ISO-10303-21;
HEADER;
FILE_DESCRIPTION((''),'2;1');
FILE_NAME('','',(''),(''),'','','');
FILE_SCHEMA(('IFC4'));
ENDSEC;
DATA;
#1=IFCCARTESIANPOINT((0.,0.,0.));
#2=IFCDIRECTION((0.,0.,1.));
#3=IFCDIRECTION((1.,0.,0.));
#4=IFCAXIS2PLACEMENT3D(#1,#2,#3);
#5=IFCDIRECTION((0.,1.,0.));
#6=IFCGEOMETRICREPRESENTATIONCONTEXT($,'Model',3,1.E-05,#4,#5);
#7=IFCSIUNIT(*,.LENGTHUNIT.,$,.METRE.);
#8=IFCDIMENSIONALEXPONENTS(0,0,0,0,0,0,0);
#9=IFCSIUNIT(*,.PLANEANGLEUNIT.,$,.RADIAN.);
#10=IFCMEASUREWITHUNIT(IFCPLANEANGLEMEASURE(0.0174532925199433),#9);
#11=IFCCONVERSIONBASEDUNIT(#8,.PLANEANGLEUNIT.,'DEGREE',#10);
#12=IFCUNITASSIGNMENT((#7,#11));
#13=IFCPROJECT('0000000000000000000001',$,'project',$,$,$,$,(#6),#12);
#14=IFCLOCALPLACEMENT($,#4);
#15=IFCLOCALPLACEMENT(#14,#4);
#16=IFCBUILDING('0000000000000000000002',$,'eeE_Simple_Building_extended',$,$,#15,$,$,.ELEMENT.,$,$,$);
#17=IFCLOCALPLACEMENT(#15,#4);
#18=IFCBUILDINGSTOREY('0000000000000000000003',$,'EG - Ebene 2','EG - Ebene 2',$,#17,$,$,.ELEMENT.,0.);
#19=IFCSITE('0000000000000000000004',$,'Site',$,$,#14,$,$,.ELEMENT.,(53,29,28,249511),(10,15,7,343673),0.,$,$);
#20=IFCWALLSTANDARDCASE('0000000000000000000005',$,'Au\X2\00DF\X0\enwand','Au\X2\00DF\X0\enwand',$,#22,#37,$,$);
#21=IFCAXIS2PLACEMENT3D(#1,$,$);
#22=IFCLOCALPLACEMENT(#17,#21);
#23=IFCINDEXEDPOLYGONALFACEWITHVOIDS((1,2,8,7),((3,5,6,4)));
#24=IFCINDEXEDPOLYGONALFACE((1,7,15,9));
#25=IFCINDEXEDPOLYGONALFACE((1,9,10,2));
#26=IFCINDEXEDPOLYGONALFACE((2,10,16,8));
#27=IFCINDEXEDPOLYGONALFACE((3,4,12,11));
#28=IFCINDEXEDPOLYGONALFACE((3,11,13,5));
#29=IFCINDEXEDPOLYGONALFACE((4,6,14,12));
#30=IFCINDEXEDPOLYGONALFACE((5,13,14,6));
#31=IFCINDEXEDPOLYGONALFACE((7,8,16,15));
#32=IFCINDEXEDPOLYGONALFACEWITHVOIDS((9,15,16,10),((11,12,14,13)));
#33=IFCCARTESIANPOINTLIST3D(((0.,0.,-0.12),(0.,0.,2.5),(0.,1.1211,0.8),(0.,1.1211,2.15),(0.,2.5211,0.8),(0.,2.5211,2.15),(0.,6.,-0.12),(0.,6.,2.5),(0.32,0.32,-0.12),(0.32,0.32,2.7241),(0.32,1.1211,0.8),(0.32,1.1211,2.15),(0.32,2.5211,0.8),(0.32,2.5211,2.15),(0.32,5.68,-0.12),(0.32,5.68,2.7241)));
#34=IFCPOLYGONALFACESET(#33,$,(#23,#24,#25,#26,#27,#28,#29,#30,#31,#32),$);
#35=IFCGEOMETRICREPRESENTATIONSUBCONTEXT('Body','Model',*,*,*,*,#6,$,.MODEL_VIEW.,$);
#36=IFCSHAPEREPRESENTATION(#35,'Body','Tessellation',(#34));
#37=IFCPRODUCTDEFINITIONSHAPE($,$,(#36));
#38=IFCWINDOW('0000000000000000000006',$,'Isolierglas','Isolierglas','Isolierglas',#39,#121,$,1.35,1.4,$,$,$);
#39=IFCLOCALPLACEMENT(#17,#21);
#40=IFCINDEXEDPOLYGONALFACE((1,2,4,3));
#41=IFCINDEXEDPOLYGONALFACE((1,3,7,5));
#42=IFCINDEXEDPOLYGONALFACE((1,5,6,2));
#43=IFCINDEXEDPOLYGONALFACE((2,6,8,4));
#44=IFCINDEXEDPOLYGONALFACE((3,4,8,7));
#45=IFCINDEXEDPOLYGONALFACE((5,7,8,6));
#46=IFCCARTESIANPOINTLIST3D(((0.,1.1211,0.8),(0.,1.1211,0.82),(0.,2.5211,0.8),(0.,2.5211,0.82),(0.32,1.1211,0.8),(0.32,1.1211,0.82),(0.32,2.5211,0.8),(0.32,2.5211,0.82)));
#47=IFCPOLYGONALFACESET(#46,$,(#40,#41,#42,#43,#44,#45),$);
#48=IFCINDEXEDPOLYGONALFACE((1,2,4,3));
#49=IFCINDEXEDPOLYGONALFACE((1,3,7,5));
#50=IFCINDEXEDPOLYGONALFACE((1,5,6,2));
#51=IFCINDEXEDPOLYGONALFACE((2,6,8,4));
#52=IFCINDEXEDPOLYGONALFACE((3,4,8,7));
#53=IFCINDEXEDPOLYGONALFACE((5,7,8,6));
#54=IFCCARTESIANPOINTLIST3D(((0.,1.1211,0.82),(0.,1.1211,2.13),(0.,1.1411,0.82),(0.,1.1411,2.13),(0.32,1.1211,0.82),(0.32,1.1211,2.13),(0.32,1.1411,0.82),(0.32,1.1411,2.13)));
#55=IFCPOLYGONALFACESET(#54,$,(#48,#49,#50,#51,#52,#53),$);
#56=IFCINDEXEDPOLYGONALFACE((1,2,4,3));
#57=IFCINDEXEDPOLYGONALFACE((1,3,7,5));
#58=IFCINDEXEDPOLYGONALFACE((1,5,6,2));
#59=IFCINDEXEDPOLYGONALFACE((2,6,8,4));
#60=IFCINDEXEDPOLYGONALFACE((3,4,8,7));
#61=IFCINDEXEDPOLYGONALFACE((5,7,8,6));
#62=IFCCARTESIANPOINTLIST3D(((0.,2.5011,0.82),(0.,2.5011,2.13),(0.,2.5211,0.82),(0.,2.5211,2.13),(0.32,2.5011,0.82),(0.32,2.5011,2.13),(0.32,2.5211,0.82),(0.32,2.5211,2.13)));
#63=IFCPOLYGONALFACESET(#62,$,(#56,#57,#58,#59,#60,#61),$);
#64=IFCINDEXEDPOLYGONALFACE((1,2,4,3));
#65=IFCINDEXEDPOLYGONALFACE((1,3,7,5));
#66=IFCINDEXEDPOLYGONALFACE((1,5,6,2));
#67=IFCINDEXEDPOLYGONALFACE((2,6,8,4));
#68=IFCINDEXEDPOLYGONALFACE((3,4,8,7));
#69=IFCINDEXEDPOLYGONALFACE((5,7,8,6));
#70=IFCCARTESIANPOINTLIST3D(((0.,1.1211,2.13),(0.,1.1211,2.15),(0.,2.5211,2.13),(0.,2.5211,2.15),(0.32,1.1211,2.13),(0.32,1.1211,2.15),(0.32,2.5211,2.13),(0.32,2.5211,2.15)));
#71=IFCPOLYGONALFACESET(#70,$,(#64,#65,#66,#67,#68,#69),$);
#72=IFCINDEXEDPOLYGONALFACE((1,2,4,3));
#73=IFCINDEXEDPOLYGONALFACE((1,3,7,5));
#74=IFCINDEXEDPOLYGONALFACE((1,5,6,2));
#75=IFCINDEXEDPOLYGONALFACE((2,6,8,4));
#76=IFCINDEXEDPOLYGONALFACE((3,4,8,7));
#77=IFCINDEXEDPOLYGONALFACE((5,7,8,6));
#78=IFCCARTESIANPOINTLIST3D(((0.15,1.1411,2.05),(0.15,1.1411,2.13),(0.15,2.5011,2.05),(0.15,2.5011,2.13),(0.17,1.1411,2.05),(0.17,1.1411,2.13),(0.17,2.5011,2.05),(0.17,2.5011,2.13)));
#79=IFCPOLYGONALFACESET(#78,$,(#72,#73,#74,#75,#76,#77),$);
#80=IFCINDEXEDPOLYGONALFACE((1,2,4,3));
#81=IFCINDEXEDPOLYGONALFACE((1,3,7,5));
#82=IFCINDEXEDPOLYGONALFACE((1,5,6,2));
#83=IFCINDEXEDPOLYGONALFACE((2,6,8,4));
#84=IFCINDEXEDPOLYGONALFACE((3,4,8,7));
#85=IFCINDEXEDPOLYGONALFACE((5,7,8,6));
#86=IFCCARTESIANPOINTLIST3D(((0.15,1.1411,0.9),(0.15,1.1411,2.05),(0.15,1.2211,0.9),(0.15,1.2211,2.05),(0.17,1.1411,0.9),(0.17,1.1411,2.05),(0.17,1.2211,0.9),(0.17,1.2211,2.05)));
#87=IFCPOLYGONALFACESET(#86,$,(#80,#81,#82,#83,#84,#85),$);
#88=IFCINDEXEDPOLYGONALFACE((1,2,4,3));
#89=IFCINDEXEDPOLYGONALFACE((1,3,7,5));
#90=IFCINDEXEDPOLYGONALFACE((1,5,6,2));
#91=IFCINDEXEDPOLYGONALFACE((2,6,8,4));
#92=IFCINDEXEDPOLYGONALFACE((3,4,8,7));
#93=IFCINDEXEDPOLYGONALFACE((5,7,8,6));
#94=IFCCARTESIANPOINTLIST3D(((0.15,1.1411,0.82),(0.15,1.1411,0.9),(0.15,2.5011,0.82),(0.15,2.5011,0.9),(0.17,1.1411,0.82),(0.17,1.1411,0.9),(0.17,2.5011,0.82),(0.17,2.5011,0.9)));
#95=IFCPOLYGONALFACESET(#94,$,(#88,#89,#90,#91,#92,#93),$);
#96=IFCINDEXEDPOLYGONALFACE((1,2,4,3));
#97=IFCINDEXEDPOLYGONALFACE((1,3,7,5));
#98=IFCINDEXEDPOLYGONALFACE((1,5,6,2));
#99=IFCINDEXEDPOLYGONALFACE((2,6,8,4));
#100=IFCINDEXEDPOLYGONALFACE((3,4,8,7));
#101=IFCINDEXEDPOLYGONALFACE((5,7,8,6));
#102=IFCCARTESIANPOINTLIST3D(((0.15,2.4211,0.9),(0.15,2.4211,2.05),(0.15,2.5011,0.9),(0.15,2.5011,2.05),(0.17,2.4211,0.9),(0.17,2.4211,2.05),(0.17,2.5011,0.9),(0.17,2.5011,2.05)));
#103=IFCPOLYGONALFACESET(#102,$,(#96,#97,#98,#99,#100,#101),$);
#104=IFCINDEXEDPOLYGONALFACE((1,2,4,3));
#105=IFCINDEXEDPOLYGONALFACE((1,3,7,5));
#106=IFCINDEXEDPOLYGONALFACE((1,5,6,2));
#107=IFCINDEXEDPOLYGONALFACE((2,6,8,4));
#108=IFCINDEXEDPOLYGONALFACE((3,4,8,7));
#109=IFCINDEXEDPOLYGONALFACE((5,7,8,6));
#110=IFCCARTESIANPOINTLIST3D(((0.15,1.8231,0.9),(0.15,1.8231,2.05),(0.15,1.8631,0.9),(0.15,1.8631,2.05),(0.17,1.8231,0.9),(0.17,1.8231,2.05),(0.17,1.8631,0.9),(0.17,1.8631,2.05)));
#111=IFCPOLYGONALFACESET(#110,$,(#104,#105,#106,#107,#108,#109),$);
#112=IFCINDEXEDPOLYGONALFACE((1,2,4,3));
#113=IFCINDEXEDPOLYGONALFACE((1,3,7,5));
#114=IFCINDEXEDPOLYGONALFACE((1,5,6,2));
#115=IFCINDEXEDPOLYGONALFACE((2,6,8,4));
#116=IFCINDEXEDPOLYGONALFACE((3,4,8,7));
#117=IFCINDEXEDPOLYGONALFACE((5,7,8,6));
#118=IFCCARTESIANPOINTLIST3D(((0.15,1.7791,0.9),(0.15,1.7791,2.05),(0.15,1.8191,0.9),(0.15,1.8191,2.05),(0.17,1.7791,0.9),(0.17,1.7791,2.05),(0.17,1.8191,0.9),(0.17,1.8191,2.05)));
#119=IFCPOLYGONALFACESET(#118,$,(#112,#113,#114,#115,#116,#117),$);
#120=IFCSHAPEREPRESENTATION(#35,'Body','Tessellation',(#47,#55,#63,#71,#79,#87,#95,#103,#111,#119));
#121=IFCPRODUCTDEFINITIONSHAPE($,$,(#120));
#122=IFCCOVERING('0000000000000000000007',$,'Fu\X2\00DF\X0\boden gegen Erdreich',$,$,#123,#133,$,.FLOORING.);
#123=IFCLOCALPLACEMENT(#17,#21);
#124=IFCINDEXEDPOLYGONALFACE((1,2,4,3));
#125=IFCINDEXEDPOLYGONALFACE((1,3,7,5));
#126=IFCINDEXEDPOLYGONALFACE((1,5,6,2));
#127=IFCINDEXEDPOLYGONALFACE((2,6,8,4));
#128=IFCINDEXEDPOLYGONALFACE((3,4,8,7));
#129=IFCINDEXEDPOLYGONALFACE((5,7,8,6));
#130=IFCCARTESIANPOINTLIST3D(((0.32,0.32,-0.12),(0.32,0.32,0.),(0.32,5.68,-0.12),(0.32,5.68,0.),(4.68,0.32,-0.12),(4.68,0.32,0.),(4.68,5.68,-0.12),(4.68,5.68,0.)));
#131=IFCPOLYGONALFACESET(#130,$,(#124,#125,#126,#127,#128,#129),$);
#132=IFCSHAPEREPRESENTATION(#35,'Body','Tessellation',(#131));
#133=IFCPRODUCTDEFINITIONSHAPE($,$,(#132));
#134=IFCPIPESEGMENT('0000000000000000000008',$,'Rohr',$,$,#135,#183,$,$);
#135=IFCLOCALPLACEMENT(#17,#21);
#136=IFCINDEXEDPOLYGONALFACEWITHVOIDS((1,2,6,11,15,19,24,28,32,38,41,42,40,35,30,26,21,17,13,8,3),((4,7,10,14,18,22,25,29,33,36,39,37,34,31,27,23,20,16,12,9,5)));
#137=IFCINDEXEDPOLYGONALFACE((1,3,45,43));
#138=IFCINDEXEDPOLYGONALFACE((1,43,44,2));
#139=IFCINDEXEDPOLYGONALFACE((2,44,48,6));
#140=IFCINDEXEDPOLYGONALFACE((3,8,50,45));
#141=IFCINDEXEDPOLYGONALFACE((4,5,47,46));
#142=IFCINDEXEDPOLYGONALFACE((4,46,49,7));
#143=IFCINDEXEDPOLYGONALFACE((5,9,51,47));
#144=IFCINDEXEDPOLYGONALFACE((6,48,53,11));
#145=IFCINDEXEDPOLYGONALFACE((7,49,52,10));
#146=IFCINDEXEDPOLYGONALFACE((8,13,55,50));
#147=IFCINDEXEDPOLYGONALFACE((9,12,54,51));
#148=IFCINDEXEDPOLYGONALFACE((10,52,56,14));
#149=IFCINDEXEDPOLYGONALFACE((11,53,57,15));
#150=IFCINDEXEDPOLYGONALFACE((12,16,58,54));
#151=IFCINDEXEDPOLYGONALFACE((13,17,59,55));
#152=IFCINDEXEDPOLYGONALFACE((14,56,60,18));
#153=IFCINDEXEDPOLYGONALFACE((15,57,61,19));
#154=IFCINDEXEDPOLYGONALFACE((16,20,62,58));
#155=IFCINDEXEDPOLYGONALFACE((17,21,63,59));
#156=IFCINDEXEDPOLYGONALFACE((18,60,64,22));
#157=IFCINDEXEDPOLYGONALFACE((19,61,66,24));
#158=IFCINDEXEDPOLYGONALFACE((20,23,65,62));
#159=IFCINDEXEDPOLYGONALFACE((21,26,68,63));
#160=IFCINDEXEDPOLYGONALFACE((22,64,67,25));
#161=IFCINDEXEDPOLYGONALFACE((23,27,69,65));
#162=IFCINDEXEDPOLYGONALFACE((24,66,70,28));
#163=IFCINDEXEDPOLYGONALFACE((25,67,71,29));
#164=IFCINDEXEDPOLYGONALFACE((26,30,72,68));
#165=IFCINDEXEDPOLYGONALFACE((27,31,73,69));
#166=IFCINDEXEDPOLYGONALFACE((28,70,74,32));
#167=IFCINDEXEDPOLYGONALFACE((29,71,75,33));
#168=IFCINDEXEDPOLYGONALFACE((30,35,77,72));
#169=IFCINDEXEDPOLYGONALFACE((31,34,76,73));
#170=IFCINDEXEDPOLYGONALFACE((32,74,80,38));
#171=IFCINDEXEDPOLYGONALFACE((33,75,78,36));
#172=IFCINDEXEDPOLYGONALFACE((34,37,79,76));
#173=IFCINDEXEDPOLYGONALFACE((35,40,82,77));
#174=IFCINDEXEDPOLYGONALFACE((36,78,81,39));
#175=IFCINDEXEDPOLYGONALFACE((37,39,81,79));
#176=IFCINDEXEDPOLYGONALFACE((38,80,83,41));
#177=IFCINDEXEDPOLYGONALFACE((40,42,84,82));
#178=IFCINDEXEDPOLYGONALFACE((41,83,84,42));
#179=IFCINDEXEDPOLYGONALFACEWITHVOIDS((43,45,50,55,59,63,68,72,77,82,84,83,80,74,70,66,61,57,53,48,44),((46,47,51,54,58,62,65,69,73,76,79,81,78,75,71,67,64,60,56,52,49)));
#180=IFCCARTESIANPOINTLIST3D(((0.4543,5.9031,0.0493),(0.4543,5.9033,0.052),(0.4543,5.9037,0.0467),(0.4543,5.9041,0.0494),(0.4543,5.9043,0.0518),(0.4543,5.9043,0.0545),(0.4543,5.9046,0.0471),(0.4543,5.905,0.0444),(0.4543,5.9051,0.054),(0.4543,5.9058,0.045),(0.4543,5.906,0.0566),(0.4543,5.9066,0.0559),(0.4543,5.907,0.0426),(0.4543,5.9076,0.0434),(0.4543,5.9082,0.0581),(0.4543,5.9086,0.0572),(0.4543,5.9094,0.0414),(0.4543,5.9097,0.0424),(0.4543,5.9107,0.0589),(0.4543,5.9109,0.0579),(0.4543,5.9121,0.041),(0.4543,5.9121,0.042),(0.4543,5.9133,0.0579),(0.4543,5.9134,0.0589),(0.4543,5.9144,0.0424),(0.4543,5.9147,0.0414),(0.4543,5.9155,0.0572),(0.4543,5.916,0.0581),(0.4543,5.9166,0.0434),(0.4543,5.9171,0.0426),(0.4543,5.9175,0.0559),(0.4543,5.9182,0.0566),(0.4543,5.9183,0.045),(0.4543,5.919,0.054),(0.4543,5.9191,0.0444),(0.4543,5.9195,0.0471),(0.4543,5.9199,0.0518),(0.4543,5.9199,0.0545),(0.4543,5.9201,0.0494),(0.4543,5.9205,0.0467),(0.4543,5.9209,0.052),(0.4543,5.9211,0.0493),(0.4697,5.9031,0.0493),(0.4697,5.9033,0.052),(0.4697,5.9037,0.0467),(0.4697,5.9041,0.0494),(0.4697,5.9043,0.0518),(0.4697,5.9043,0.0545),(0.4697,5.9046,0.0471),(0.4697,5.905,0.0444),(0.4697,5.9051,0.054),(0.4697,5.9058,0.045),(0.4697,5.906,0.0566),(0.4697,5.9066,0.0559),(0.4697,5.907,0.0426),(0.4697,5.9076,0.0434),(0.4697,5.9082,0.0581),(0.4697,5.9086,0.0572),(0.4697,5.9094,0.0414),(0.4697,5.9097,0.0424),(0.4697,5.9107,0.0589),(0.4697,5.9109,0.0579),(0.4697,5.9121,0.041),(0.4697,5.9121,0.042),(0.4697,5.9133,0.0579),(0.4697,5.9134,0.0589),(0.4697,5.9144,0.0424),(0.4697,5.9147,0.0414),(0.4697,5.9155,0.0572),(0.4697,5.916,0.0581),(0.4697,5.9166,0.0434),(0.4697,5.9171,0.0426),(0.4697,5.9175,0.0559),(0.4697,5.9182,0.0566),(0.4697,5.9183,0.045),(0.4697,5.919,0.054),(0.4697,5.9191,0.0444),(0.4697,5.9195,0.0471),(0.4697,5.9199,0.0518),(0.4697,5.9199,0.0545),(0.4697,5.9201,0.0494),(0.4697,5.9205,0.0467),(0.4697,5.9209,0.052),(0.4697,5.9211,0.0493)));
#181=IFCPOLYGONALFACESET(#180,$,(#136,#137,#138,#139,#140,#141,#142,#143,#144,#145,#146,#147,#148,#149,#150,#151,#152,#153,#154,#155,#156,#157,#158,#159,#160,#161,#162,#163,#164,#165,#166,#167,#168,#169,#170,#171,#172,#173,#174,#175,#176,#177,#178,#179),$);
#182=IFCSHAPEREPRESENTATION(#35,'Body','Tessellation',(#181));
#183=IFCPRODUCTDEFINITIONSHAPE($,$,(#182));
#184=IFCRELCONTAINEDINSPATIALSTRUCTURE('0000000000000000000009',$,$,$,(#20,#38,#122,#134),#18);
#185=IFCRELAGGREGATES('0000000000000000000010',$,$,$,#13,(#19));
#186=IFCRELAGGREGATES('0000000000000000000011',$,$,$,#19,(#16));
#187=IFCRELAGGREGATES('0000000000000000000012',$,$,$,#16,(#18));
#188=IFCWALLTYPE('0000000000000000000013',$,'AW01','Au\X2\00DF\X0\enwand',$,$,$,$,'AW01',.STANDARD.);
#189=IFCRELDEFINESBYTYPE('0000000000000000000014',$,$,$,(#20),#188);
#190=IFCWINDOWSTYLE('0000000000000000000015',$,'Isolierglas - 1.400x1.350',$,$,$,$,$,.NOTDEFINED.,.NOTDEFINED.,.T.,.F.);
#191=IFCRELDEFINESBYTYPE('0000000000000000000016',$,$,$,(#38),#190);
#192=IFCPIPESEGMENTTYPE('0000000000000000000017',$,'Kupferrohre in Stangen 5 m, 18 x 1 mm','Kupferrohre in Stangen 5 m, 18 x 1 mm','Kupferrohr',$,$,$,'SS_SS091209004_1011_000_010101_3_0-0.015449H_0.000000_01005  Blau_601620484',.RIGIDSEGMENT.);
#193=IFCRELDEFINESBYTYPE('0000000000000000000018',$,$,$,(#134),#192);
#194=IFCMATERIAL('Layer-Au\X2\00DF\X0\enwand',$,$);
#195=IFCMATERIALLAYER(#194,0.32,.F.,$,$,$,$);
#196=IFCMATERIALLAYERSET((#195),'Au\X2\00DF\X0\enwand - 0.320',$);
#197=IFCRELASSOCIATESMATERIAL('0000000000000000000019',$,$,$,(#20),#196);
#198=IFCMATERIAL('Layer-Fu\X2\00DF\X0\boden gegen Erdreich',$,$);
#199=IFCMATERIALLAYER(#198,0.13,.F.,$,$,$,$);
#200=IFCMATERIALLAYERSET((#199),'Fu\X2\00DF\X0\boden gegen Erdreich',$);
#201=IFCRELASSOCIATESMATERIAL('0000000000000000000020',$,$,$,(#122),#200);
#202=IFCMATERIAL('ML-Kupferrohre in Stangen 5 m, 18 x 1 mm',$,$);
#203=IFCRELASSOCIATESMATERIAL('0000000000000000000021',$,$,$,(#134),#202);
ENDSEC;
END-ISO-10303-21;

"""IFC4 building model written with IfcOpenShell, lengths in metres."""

from ifc_helpers import new_model, entity, si_unit, converted_unit, direction, frame, origin_with_axes, origin_2d_with_axis, place, context, subcontext, project, spatial, polyline, rectangle, hollow_circle, outline, extrude, clip, bounded_halfspace, source, transform, mapped, material, layer, layer_set, layer_usage, type_object, element, fill, save


model = new_model("IFC4")

# Units and contexts
model_context = context("Model", 3, precision=1e-05, world=origin_with_axes(), true_north=direction((0.0, 1.0, 0.0)))
body_context = subcontext(model_context, "Body", "Model", "MODEL_VIEW")
ifc_project = project(units=[si_unit("LENGTHUNIT", "METRE"), converted_unit("PLANEANGLEUNIT", "DEGREE", entity("IfcPlaneAngleMeasure", 0.0174532925199433), si_unit("PLANEANGLEUNIT", "RADIAN"), dimensions=[0, 0, 0, 0, 0, 0, 0])], contexts=[model_context])

# Site, building, storey
site_placement = place(None, origin_with_axes())
site = spatial("IfcSite", under=ifc_project, at=site_placement, Name="Site", CompositionType="ELEMENT", RefLatitude=(53, 29, 28, 249511), RefLongitude=(10, 15, 7, 343673), RefElevation=0.0)
building_placement = place(site_placement, origin_with_axes())
building = spatial("IfcBuilding", under=site, at=building_placement, Name="eeE_Simple_Building_extended", CompositionType="ELEMENT")
storey_placement = place(building_placement, origin_with_axes())
storey = spatial("IfcBuildingStorey", under=building, at=storey_placement, Name="EG - Ebene 2", Description="EG - Ebene 2", CompositionType="ELEMENT", Elevation=0.0)

# Wall, opening, window
ifc_material_1 = material(Name="Layer-Außenwand")
ifc_layer_1 = layer(ifc_material_1, 0.32, ventilated=False)
ifc_layer_set_1 = layer_set([ifc_layer_1], Name="Außenwand - 0.320")
ifc_layer_usage_1 = layer_usage(ifc_layer_set_1, "AXIS2", "POSITIVE", 0.0)
wall_type = type_object("IfcWallType", Name="AW01", Description="Außenwand", ElementType="AW01", PredefinedType="STANDARD")
wall_placement = place(storey_placement, frame((0.32, 5.68, -0.12), z_axis=(0.0, 0.0, 1.0), x_axis=(0.0, -1.0, 0.0)))
wall = element("IfcWallStandardCase", 1, at=wall_placement, inside=storey, type_object=wall_type, material=ifc_layer_usage_1, Name="Außenwand", Description="Außenwand", context=body_context, shape_type="Clipping", body=[
    clip(extrude(outline(polyline([(0.0, 0.0), (5.36, 0.0), (5.68, 0.32), (-0.32, 0.32), (0.0, 0.0)])), frame((0.0, 0.0, 0.0), z_axis=(0.0, 0.0, -1.0), x_axis=(1.0, 0.0, 0.0)), (0.0, 0.0, -1.0), 4.3705), bounded_halfspace(frame((6.08, 2.18, 4.3705), z_axis=(0.0, 0.573576, -0.819152), x_axis=(1.0, 0.0, 0.0)), True, frame((6.08, 2.18, 0.12), z_axis=(0.0, 0.0, 1.0), x_axis=(-1.0, 0.0, 0.0)), polyline([(0.0, 0.0), (6.8, 0.0), (6.8, 2.9), (0.0, 2.9), (0.0, 0.0)]))),
])
opening_placement = place(wall_placement, frame((4.5589, -0.42, 0.92), z_axis=(0.0, 0.0, 1.0), x_axis=(1.0, 0.0, 0.0)))
opening = element("IfcOpeningElement", 2, at=opening_placement, cuts=wall, context=body_context, shape_type="SweptSolid", body=[
    extrude(outline(polyline([(0.0, 0.0), (1.4, 0.0), (1.4, 1.35), (0.0, 1.35), (0.0, 0.0), (0.0, 0.0)])), frame((0.0, 0.0, 0.0), z_axis=(0.0, 1.0, 0.0), x_axis=(-1.0, 0.0, 0.0)), (0.0, 0.0, 1.0), 0.52),
])
window_style = type_object("IfcWindowStyle", Name="Isolierglas - 1.400x1.350", ConstructionType="NOTDEFINED", OperationType="NOTDEFINED", ParameterTakesPrecedence=True, Sizeable=False)
shared_shape_1 = source(origin_with_axes(), body_context, "Body", "SweptSolid", [
    extrude(rectangle(XDim=1.4, YDim=0.32, at=origin_2d_with_axis()), frame((0.7, 0.16, 0.0), z_axis=(0.0, 0.0, 1.0), x_axis=(1.0, 0.0, 0.0)), (0.0, 0.0, 1.0), 0.02),
    extrude(rectangle(XDim=0.02, YDim=0.32, at=origin_2d_with_axis()), frame((0.01, 0.16, 0.02), z_axis=(0.0, 0.0, 1.0), x_axis=(1.0, 0.0, 0.0)), (0.0, 0.0, 1.0), 1.31),
    extrude(rectangle(XDim=0.02, YDim=0.32, at=origin_2d_with_axis()), frame((1.39, 0.16, 0.02), z_axis=(0.0, 0.0, 1.0), x_axis=(1.0, 0.0, 0.0)), (0.0, 0.0, 1.0), 1.31),
    extrude(rectangle(XDim=1.4, YDim=0.32, at=origin_2d_with_axis()), frame((0.7, 0.16, 1.33), z_axis=(0.0, 0.0, 1.0), x_axis=(1.0, 0.0, 0.0)), (0.0, 0.0, 1.0), 0.02),
    extrude(rectangle(XDim=1.36, YDim=0.02, at=origin_2d_with_axis()), frame((0.7, 0.16, 1.25), z_axis=(0.0, 0.0, 1.0), x_axis=(1.0, 0.0, 0.0)), (0.0, 0.0, 1.0), 0.08),
    extrude(rectangle(XDim=0.08, YDim=0.02, at=origin_2d_with_axis()), frame((0.06, 0.16, 0.1), z_axis=(0.0, 0.0, 1.0), x_axis=(1.0, 0.0, 0.0)), (0.0, 0.0, 1.0), 1.15),
    extrude(rectangle(XDim=1.36, YDim=0.02, at=origin_2d_with_axis()), frame((0.7, 0.16, 0.02), z_axis=(0.0, 0.0, 1.0), x_axis=(1.0, 0.0, 0.0)), (0.0, 0.0, 1.0), 0.08),
    extrude(rectangle(XDim=0.08, YDim=0.02, at=origin_2d_with_axis()), frame((1.34, 0.16, 0.1), z_axis=(0.0, 0.0, 1.0), x_axis=(1.0, 0.0, 0.0)), (0.0, 0.0, 1.0), 1.15),
    extrude(rectangle(XDim=0.04, YDim=0.02, at=origin_2d_with_axis()), frame((0.722, 0.16, 0.1), z_axis=(0.0, 0.0, 1.0), x_axis=(1.0, 0.0, 0.0)), (0.0, 0.0, 1.0), 1.15),
    extrude(rectangle(XDim=0.04, YDim=0.02, at=origin_2d_with_axis()), frame((0.678, 0.16, 0.1), z_axis=(0.0, 0.0, 1.0), x_axis=(1.0, 0.0, 0.0)), (0.0, 0.0, 1.0), 1.15),
])
window_placement = place(opening_placement, frame((0.0, 0.1, 0.0), z_axis=(0.0, 0.0, 1.0), x_axis=(-1.0, 0.0, 0.0)))
window = element("IfcWindow", 3, at=window_placement, inside=storey, type_object=window_style, Name="Isolierglas", Description="Isolierglas", ObjectType="Isolierglas", OverallHeight=1.35, OverallWidth=1.4, context=body_context, shape_type="MappedRepresentation", body=[
    mapped(shared_shape_1, transform((0.0, -0.32, 0.0), x_axis=(1.0, 0.0, 0.0), y_axis=(0.0, 1.0, 0.0), z_axis=(0.0, 0.0, 1.0), scale=1.0)),
])
fill(opening, window)

# Covering
ifc_material_2 = material(Name="Layer-Fußboden gegen Erdreich")
ifc_layer_2 = layer(ifc_material_2, 0.13, ventilated=False)
ifc_layer_set_2 = layer_set([ifc_layer_2], Name="Fußboden gegen Erdreich")
ifc_layer_usage_2 = layer_usage(ifc_layer_set_2, "AXIS2", "POSITIVE", 0.0)
covering_placement = place(storey_placement, frame((0.32, 5.68, -0.12), z_axis=(0.0, 0.0, 1.0), x_axis=(1.0, 0.0, 0.0)))
element("IfcCovering", 4, at=covering_placement, inside=storey, material=ifc_layer_usage_2, Name="Fußboden gegen Erdreich", PredefinedType="FLOORING", context=body_context, shape_type="SweptSolid", body=[
    extrude(outline(polyline([(0.0, 0.0), (5.36, 0.0), (5.36, 4.36), (0.0, 4.36), (0.0, 0.0)])), frame((0.0, 0.0, 0.0), z_axis=(0.0, 0.0, 1.0), x_axis=(0.0, -1.0, 0.0)), (0.0, 0.0, 1.0), 0.12),
])

# Pipe segment
ifc_material_3 = material(Name="ML-Kupferrohre in Stangen 5 m, 18 x 1 mm")
pipe_segment_type_1 = type_object("IfcPipeSegmentType", Name="Kupferrohre in Stangen 5 m, 18 x 1 mm", Description="Kupferrohre in Stangen 5 m, 18 x 1 mm", ApplicableOccurrence="Kupferrohr", ElementType="SS_SS091209004_1011_000_010101_3_0-0.015449H_0.000000_01005  Blau_601620484", PredefinedType="RIGIDSEGMENT")
pipe_segment_1_placement = place(storey_placement, frame((0.4697, 5.9121, 0.05), z_axis=(0.0, 0.0, 1.0), x_axis=(1.0, 0.0, 0.0)))
element("IfcPipeSegment", 5, at=pipe_segment_1_placement, inside=storey, type_object=pipe_segment_type_1, material=ifc_material_3, Name="Rohr", context=body_context, shape_type="SweptSolid", body=[
    extrude(hollow_circle(Radius=0.009, WallThickness=0.001, at=origin_2d_with_axis()), frame((0.0, 0.0, 0.0), z_axis=(1.0, 0.0, 0.0), x_axis=(0.0, 0.0, -1.0)), (0.0, 0.0, -1.0), 0.0154),
])

save(model, "model.ifc")
